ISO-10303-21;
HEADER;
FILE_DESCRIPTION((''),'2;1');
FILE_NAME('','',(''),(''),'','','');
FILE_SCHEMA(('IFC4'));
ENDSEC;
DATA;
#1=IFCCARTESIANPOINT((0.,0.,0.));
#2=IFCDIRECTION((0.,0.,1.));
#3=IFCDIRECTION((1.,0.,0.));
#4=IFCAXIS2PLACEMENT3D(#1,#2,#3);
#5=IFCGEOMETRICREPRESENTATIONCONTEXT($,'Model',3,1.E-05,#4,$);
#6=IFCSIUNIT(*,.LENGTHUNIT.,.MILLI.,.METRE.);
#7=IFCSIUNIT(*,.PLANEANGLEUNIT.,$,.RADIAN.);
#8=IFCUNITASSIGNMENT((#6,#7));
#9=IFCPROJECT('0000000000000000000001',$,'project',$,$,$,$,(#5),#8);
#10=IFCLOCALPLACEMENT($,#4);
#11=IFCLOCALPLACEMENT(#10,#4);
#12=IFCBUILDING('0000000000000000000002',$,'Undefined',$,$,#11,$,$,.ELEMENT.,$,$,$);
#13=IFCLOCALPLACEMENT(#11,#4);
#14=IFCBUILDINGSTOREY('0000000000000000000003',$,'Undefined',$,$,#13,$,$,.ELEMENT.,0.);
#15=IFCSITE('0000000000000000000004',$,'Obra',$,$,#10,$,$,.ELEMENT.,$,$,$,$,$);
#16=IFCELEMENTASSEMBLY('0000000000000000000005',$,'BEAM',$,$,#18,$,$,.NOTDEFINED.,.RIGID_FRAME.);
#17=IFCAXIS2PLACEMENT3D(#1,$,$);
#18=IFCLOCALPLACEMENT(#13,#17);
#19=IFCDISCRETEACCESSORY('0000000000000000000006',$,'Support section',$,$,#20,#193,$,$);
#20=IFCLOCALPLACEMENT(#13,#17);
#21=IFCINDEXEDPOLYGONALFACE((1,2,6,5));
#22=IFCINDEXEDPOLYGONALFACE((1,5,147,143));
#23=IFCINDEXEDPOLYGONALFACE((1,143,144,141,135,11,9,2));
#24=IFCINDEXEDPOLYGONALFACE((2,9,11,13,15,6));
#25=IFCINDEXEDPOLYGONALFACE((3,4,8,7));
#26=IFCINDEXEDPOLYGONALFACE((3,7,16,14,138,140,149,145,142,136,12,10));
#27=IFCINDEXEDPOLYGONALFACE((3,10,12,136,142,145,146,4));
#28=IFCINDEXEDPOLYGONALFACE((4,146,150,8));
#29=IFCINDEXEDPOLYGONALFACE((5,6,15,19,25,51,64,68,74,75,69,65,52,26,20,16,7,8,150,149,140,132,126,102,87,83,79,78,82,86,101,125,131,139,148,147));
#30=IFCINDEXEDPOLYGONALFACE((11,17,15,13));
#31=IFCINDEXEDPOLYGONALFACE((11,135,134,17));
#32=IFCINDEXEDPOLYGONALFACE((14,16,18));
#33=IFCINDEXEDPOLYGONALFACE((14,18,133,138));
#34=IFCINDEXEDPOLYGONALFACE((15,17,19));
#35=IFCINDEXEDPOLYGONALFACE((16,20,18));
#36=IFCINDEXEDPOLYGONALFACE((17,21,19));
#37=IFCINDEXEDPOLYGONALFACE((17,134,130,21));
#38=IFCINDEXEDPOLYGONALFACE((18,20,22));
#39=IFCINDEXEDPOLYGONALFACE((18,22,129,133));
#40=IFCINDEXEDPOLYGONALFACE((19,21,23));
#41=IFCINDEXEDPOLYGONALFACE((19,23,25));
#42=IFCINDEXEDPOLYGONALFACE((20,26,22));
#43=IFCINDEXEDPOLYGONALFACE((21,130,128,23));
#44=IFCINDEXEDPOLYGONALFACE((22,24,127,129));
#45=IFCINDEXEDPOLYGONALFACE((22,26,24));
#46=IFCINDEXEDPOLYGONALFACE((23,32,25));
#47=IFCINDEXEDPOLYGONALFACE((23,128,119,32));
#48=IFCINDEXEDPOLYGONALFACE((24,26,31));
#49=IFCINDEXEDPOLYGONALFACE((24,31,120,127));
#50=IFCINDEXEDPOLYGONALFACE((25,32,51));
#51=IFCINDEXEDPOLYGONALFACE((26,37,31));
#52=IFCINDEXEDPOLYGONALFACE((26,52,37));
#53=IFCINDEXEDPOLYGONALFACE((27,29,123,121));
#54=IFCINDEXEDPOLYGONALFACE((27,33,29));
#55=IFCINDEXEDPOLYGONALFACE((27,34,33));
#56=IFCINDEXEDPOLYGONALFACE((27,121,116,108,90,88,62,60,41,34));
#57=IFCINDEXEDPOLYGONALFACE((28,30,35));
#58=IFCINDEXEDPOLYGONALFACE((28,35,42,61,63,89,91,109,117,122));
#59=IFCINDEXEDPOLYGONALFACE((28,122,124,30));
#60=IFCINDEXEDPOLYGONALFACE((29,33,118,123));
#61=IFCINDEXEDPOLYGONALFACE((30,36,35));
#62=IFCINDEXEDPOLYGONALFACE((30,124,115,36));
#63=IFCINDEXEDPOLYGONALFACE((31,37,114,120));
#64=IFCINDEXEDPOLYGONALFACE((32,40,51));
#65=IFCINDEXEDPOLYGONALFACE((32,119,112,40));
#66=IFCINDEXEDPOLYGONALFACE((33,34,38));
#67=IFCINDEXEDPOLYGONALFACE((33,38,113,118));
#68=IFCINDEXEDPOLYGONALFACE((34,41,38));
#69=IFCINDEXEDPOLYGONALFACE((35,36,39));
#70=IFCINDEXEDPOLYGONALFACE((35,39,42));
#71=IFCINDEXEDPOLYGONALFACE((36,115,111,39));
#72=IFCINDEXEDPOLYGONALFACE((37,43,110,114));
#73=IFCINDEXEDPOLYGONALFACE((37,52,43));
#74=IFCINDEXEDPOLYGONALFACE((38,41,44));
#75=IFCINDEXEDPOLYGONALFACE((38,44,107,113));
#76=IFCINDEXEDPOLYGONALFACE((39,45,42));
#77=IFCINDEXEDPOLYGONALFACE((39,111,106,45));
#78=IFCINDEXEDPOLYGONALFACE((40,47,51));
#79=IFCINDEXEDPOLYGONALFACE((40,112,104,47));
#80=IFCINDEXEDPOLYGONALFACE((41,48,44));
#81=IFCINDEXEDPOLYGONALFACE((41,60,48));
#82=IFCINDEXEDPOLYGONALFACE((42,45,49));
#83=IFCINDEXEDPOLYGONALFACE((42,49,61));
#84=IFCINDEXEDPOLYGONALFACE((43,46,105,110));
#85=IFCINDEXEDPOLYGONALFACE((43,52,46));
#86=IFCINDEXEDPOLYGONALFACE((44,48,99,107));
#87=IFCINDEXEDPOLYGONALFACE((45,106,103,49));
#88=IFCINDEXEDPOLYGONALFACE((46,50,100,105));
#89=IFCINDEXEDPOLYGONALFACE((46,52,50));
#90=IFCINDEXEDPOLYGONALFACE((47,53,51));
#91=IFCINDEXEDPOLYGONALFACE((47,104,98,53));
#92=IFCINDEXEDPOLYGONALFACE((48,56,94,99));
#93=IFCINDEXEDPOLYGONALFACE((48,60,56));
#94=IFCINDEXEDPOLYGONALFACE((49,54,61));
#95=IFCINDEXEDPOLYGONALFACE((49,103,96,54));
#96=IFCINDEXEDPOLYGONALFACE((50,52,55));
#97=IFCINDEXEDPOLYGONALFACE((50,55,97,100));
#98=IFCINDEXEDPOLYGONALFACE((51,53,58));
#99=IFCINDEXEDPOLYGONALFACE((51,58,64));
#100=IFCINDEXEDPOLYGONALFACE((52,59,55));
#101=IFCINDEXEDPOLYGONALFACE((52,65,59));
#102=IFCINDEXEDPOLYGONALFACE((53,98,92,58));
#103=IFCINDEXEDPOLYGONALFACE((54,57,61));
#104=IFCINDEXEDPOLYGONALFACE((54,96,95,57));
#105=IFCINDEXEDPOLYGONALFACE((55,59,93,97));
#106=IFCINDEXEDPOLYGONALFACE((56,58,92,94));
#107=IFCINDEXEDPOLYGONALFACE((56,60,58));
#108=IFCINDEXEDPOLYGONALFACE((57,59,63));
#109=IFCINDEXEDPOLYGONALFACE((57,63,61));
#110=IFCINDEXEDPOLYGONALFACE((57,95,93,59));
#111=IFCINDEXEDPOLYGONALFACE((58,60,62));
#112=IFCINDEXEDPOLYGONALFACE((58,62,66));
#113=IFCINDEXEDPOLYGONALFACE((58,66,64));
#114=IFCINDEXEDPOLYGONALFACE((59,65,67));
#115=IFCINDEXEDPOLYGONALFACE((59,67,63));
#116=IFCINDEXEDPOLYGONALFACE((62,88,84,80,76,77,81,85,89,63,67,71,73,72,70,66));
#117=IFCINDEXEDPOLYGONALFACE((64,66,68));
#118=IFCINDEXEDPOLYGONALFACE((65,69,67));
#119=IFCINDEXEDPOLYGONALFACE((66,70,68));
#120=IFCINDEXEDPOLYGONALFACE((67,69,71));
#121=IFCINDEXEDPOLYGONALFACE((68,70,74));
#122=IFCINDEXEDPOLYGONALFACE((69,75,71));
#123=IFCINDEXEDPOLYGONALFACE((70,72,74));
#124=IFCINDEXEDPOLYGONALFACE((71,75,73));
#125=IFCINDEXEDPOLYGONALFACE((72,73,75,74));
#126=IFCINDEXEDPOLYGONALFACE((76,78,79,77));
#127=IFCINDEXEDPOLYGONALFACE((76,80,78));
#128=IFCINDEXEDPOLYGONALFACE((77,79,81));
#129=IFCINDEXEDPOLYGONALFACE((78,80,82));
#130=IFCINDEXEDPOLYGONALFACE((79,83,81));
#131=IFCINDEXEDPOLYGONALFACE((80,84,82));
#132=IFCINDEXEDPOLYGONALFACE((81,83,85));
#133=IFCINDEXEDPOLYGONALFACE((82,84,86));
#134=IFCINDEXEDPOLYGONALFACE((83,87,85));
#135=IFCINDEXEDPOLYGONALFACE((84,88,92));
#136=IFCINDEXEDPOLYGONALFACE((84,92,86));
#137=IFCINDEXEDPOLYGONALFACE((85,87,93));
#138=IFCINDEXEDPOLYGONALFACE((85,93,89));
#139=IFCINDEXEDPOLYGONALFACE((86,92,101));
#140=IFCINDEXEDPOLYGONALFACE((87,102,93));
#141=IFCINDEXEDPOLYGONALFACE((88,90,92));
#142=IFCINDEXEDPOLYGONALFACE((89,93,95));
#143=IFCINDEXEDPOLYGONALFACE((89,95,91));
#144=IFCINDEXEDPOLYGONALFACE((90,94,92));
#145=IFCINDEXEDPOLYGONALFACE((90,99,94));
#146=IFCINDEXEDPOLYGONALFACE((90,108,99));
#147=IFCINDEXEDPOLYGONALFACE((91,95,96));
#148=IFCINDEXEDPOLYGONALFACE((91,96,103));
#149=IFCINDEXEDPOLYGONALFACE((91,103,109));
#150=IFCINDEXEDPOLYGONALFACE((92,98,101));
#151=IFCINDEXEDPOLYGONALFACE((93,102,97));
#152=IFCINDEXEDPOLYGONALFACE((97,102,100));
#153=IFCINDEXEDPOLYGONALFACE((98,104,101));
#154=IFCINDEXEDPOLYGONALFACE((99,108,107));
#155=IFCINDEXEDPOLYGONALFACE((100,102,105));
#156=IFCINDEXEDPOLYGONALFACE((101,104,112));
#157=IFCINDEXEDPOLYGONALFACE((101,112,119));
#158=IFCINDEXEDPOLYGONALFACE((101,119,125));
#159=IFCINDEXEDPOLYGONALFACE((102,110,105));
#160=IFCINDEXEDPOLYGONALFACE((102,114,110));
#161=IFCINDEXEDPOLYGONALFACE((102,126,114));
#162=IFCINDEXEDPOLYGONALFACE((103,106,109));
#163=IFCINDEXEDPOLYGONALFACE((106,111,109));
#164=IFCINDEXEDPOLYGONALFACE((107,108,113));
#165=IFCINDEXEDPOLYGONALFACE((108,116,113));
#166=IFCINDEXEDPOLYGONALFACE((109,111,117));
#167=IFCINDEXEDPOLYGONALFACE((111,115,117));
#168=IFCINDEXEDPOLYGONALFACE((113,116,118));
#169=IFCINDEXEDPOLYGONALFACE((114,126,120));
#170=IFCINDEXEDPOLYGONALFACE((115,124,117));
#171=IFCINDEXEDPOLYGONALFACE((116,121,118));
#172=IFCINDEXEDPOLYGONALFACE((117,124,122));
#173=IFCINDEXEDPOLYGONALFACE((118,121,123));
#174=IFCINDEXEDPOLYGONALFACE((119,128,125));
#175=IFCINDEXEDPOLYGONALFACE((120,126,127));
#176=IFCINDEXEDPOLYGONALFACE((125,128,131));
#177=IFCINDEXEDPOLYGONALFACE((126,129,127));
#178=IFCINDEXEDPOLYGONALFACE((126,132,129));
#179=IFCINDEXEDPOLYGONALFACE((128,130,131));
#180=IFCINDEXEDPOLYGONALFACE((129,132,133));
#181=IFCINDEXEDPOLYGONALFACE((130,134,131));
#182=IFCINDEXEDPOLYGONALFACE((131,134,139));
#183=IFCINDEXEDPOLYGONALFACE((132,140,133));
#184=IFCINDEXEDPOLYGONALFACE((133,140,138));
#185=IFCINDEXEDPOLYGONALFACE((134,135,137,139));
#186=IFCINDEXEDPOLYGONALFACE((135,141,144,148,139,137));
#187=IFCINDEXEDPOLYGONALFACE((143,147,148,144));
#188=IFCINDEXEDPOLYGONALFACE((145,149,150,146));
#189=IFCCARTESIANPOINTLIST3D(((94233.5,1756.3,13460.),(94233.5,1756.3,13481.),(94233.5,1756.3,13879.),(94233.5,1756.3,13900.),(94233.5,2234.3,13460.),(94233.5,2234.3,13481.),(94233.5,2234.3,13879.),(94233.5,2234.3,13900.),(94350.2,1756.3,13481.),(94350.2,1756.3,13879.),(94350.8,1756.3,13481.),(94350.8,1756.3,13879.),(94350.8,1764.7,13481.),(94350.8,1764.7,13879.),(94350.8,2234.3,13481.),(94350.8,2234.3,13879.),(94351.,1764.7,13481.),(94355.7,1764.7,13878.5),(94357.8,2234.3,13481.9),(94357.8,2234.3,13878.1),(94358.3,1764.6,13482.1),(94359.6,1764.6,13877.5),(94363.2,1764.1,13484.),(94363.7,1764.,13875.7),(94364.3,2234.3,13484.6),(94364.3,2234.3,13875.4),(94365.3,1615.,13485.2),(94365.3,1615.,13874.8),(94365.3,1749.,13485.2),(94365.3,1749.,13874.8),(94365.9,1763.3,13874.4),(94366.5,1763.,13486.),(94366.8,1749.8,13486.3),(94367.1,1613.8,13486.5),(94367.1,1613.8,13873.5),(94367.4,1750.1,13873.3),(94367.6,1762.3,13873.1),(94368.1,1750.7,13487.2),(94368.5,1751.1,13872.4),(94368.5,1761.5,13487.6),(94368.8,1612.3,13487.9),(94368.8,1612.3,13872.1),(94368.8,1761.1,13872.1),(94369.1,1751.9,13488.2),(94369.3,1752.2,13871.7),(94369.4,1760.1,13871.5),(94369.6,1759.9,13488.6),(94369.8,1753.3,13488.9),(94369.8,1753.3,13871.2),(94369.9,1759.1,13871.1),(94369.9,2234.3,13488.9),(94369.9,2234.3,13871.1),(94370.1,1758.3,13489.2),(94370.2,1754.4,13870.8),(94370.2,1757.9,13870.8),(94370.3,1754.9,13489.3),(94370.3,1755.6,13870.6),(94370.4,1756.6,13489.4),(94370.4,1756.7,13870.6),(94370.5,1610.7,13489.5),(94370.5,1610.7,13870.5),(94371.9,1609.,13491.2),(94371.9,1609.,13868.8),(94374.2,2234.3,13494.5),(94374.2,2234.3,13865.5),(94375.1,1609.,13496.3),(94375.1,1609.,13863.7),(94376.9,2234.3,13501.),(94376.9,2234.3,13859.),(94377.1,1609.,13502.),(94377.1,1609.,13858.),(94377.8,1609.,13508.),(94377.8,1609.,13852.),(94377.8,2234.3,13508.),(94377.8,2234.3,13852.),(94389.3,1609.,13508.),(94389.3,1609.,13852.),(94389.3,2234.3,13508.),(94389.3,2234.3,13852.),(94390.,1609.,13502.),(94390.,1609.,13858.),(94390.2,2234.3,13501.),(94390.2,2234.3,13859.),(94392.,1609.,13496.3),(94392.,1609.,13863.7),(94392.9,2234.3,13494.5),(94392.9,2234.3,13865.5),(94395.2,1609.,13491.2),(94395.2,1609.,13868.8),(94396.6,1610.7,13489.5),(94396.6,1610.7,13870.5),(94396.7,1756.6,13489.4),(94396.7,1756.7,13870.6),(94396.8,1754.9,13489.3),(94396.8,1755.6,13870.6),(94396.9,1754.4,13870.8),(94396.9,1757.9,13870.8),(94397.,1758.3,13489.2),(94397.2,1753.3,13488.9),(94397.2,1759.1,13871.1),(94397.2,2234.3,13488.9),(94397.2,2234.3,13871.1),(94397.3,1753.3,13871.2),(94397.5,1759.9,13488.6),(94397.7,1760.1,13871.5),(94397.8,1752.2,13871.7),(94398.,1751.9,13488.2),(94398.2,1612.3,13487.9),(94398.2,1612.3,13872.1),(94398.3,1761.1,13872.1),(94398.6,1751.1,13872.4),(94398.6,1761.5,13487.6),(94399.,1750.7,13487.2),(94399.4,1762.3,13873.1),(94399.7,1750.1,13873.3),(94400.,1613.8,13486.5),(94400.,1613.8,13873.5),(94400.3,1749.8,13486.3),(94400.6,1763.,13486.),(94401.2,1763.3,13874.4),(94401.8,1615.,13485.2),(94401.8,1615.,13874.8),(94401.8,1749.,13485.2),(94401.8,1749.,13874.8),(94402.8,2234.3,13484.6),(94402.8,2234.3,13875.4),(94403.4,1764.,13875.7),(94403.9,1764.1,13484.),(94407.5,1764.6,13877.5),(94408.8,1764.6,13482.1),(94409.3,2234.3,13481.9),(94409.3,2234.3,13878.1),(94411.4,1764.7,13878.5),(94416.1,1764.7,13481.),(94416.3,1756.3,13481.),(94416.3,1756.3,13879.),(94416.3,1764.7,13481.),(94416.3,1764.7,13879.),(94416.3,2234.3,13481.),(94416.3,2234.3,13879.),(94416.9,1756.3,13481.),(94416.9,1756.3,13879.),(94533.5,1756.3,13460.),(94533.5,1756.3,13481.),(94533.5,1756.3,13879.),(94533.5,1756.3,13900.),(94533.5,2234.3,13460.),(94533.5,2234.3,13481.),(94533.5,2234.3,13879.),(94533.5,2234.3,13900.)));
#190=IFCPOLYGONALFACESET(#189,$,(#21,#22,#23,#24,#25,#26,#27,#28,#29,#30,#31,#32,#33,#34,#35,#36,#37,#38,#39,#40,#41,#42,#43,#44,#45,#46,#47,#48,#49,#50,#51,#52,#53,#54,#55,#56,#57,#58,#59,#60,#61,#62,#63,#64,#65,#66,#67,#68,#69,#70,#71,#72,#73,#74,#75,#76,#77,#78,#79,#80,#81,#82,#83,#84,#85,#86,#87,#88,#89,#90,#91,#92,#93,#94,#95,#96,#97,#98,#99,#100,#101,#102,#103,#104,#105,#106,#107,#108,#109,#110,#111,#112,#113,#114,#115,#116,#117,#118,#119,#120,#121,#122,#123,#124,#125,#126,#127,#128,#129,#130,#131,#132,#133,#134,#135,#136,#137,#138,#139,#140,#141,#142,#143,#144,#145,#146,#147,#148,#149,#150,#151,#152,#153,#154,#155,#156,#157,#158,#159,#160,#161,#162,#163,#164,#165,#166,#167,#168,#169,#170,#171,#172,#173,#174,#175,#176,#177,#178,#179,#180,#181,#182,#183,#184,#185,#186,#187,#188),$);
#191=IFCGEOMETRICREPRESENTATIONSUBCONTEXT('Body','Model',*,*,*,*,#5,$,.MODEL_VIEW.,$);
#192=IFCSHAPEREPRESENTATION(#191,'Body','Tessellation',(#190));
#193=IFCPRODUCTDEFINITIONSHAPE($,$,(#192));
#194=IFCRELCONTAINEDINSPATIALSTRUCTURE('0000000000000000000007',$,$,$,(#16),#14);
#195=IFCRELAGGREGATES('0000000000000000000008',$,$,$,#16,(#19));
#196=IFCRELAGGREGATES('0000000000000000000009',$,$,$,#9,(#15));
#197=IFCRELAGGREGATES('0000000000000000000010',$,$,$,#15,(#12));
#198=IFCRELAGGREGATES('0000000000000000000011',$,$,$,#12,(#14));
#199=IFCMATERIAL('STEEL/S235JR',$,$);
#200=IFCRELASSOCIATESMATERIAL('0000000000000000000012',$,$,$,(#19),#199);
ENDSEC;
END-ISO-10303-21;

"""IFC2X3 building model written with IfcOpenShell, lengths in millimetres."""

from ifc_helpers import new_model, si_unit, frame, frame_2d, origin_with_axes, origin_2d_with_axis, place, context, subcontext, project, spatial, polyline, circle_curve, parameter, trimmed, segment, composite_curve, rectangle, i_section, outline, extrude, clip, halfspace, material, element, aggregate, save


model = new_model("IFC2X3")

# Units and contexts
model_context = context("Model", 3, precision=1e-05, world=origin_with_axes())
body_context = subcontext(model_context, "Body", "Model", "MODEL_VIEW")
ifc_project = project(units=[si_unit("LENGTHUNIT", "METRE", prefix="MILLI"), si_unit("PLANEANGLEUNIT", "RADIAN")], contexts=[model_context])

# Site, building, storey
site_placement = place(None, origin_with_axes())
site = spatial("IfcSite", under=ifc_project, at=site_placement, Name="Obra", CompositionType="ELEMENT")
building_placement = place(site_placement, origin_with_axes())
building = spatial("IfcBuilding", under=site, at=building_placement, Name="Undefined", CompositionType="ELEMENT")
storey_placement = place(building_placement, origin_with_axes())
storey = spatial("IfcBuildingStorey", under=building, at=storey_placement, Name="Undefined", CompositionType="ELEMENT", Elevation=0.0)

# Shared definitions
ifc_material_1 = material(Name="STEEL/S235JR")

# Element assembly
assembly_1_placement = place(storey_placement, origin_with_axes())
assembly_1 = element("IfcElementAssembly", 1, at=assembly_1_placement, inside=storey, Name="BEAM", AssemblyPlace="NOTDEFINED", PredefinedType="RIGID_FRAME")

# Discrete accessory, openings
discrete_accessory_1_placement = place(assembly_1_placement, frame((94383.5, 1609.0, 13680.0), z_axis=(0.0, 0.0, 1.0), x_axis=(0.0, 1.0, 0.0)))
discrete_accessory_1 = element("IfcDiscreteAccessory", 2, at=discrete_accessory_1_placement, material=ifc_material_1, Name="Support section", context=body_context, shape_type="Clipping", body=[
    clip(clip(extrude(i_section(OverallWidth=300.0, OverallDepth=440.0, WebThickness=11.5, FlangeThickness=21.0, FilletRadius=27.0, at=origin_2d_with_axis()), frame((625.2, 0.0, 0.0), z_axis=(-1.0, 0.0, 0.0), x_axis=(0.0, -1.0, 0.0)), (0.0, 0.0, 1.0), 625.2), halfspace(frame((625.2, 1000.0, 0.0), z_axis=(-1.0, 0.0, 0.0), x_axis=(0.0, 0.0, 1.0)), True)), halfspace(frame((0.0, 0.0, 1000.0), z_axis=(-1.0, 0.0, 0.0), x_axis=(0.0, -1.0, 0.0)), False)),
])
opening_1_placement = place(assembly_1_placement, frame((94383.5, 1609.0, 13680.0), z_axis=(0.0, 0.0, 1.0), x_axis=(0.0, 1.0, 0.0)))
element("IfcOpeningElement", 3, at=opening_1_placement, cuts=discrete_accessory_1, ObjectType="Recess", context=body_context, shape_type="SweptSolid", body=[
    extrude(outline(composite_curve([segment(trimmed(circle_curve(frame_2d((5.9, 5.9), x_axis=(-0.707107, 0.707107)), 8.4), [parameter(0.0)], [parameter(3.141593)], True, "PARAMETER"), True, "CONTINUOUS"), segment(polyline([(11.9, 0.0), (0.0, 11.9)]), True, "CONTINUOUS")], self_intersect=True)), frame((147.3, 33.3, -190.6), z_axis=(0.0, -1.0, 0.0), x_axis=(-0.707107, 0.0, -0.707107)), (0.0, 0.0, 1.0), 66.7),
])
opening_2_placement = place(assembly_1_placement, frame((94383.5, 1609.0, 13680.0), z_axis=(0.0, 0.0, 1.0), x_axis=(0.0, 1.0, 0.0)))
element("IfcOpeningElement", 4, at=opening_2_placement, cuts=discrete_accessory_1, ObjectType="Recess", context=body_context, shape_type="SweptSolid", body=[
    extrude(outline(polyline([(0.0, 0.0), (15.8, 0.0), (7.9, 7.9), (0.0, 0.0)])), frame((10.7, 33.3, -199.5), z_axis=(0.0, -1.0, 0.0), x_axis=(-0.707107, 0.0, 0.707107)), (0.0, 0.0, 1.0), 66.7),
])
opening_3_placement = place(assembly_1_placement, frame((94383.5, 1609.0, 13680.0), z_axis=(0.0, 0.0, 1.0), x_axis=(0.0, 1.0, 0.0)))
element("IfcOpeningElement", 5, at=opening_3_placement, cuts=discrete_accessory_1, ObjectType="Recess", context=body_context, shape_type="SweptSolid", body=[
    extrude(outline(composite_curve([segment(trimmed(circle_curve(frame_2d((5.9, 5.9), x_axis=(-0.707107, -0.707107)), 8.4), [parameter(0.0)], [parameter(3.141593)], True, "PARAMETER"), True, "CONTINUOUS"), segment(polyline([(11.9, 11.9), (0.0, 0.0)]), True, "CONTINUOUS")], self_intersect=True)), frame((138.9, 33.3, 199.0), z_axis=(0.0, -1.0, 0.0), x_axis=(0.707107, 0.0, -0.707107)), (0.0, 0.0, 1.0), 66.7),
])
opening_4_placement = place(assembly_1_placement, frame((94383.5, 1609.0, 13680.0), z_axis=(0.0, 0.0, 1.0), x_axis=(0.0, 1.0, 0.0)))
element("IfcOpeningElement", 6, at=opening_4_placement, cuts=discrete_accessory_1, ObjectType="Recess", context=body_context, shape_type="SweptSolid", body=[
    extrude(outline(polyline([(0.0, 0.0), (15.8, 0.0), (7.9, 7.9), (0.0, 0.0)])), frame((-0.5, 33.4, 188.3), z_axis=(0.0, -1.0, 0.0), x_axis=(0.707107, 0.0, 0.707107)), (0.0, 0.0, 1.0), 66.7),
])
opening_5_placement = place(assembly_1_placement, frame((94383.5, 1609.0, 13680.0), z_axis=(0.0, 0.0, 1.0), x_axis=(0.0, 1.0, 0.0)))
element("IfcOpeningElement", 7, at=opening_5_placement, cuts=discrete_accessory_1, ObjectType="Recess", context=body_context, shape_type="SweptSolid", body=[
    extrude(rectangle(XDim=27.2, YDim=150.0, at=origin_2d_with_axis()), frame((72.2, -152.0, -208.4), z_axis=(0.0, 1.0, 0.0), x_axis=(0.0, 0.0, -1.0)), (0.0, 0.0, 1.0), 304.0),
])
opening_6_placement = place(assembly_1_placement, frame((94383.5, 1609.0, 13680.0), z_axis=(0.0, 0.0, 1.0), x_axis=(0.0, 1.0, 0.0)))
element("IfcOpeningElement", 8, at=opening_6_placement, cuts=discrete_accessory_1, ObjectType="Recess", context=body_context, shape_type="SweptSolid", body=[
    extrude(rectangle(XDim=27.2, YDim=150.0, at=origin_2d_with_axis()), frame((72.2, -152.0, 208.4), z_axis=(0.0, 1.0, 0.0), x_axis=(0.0, 0.0, -1.0)), (0.0, 0.0, 1.0), 304.0),
])

aggregate(assembly_1, [discrete_accessory_1])

save(model, "model.ifc")
